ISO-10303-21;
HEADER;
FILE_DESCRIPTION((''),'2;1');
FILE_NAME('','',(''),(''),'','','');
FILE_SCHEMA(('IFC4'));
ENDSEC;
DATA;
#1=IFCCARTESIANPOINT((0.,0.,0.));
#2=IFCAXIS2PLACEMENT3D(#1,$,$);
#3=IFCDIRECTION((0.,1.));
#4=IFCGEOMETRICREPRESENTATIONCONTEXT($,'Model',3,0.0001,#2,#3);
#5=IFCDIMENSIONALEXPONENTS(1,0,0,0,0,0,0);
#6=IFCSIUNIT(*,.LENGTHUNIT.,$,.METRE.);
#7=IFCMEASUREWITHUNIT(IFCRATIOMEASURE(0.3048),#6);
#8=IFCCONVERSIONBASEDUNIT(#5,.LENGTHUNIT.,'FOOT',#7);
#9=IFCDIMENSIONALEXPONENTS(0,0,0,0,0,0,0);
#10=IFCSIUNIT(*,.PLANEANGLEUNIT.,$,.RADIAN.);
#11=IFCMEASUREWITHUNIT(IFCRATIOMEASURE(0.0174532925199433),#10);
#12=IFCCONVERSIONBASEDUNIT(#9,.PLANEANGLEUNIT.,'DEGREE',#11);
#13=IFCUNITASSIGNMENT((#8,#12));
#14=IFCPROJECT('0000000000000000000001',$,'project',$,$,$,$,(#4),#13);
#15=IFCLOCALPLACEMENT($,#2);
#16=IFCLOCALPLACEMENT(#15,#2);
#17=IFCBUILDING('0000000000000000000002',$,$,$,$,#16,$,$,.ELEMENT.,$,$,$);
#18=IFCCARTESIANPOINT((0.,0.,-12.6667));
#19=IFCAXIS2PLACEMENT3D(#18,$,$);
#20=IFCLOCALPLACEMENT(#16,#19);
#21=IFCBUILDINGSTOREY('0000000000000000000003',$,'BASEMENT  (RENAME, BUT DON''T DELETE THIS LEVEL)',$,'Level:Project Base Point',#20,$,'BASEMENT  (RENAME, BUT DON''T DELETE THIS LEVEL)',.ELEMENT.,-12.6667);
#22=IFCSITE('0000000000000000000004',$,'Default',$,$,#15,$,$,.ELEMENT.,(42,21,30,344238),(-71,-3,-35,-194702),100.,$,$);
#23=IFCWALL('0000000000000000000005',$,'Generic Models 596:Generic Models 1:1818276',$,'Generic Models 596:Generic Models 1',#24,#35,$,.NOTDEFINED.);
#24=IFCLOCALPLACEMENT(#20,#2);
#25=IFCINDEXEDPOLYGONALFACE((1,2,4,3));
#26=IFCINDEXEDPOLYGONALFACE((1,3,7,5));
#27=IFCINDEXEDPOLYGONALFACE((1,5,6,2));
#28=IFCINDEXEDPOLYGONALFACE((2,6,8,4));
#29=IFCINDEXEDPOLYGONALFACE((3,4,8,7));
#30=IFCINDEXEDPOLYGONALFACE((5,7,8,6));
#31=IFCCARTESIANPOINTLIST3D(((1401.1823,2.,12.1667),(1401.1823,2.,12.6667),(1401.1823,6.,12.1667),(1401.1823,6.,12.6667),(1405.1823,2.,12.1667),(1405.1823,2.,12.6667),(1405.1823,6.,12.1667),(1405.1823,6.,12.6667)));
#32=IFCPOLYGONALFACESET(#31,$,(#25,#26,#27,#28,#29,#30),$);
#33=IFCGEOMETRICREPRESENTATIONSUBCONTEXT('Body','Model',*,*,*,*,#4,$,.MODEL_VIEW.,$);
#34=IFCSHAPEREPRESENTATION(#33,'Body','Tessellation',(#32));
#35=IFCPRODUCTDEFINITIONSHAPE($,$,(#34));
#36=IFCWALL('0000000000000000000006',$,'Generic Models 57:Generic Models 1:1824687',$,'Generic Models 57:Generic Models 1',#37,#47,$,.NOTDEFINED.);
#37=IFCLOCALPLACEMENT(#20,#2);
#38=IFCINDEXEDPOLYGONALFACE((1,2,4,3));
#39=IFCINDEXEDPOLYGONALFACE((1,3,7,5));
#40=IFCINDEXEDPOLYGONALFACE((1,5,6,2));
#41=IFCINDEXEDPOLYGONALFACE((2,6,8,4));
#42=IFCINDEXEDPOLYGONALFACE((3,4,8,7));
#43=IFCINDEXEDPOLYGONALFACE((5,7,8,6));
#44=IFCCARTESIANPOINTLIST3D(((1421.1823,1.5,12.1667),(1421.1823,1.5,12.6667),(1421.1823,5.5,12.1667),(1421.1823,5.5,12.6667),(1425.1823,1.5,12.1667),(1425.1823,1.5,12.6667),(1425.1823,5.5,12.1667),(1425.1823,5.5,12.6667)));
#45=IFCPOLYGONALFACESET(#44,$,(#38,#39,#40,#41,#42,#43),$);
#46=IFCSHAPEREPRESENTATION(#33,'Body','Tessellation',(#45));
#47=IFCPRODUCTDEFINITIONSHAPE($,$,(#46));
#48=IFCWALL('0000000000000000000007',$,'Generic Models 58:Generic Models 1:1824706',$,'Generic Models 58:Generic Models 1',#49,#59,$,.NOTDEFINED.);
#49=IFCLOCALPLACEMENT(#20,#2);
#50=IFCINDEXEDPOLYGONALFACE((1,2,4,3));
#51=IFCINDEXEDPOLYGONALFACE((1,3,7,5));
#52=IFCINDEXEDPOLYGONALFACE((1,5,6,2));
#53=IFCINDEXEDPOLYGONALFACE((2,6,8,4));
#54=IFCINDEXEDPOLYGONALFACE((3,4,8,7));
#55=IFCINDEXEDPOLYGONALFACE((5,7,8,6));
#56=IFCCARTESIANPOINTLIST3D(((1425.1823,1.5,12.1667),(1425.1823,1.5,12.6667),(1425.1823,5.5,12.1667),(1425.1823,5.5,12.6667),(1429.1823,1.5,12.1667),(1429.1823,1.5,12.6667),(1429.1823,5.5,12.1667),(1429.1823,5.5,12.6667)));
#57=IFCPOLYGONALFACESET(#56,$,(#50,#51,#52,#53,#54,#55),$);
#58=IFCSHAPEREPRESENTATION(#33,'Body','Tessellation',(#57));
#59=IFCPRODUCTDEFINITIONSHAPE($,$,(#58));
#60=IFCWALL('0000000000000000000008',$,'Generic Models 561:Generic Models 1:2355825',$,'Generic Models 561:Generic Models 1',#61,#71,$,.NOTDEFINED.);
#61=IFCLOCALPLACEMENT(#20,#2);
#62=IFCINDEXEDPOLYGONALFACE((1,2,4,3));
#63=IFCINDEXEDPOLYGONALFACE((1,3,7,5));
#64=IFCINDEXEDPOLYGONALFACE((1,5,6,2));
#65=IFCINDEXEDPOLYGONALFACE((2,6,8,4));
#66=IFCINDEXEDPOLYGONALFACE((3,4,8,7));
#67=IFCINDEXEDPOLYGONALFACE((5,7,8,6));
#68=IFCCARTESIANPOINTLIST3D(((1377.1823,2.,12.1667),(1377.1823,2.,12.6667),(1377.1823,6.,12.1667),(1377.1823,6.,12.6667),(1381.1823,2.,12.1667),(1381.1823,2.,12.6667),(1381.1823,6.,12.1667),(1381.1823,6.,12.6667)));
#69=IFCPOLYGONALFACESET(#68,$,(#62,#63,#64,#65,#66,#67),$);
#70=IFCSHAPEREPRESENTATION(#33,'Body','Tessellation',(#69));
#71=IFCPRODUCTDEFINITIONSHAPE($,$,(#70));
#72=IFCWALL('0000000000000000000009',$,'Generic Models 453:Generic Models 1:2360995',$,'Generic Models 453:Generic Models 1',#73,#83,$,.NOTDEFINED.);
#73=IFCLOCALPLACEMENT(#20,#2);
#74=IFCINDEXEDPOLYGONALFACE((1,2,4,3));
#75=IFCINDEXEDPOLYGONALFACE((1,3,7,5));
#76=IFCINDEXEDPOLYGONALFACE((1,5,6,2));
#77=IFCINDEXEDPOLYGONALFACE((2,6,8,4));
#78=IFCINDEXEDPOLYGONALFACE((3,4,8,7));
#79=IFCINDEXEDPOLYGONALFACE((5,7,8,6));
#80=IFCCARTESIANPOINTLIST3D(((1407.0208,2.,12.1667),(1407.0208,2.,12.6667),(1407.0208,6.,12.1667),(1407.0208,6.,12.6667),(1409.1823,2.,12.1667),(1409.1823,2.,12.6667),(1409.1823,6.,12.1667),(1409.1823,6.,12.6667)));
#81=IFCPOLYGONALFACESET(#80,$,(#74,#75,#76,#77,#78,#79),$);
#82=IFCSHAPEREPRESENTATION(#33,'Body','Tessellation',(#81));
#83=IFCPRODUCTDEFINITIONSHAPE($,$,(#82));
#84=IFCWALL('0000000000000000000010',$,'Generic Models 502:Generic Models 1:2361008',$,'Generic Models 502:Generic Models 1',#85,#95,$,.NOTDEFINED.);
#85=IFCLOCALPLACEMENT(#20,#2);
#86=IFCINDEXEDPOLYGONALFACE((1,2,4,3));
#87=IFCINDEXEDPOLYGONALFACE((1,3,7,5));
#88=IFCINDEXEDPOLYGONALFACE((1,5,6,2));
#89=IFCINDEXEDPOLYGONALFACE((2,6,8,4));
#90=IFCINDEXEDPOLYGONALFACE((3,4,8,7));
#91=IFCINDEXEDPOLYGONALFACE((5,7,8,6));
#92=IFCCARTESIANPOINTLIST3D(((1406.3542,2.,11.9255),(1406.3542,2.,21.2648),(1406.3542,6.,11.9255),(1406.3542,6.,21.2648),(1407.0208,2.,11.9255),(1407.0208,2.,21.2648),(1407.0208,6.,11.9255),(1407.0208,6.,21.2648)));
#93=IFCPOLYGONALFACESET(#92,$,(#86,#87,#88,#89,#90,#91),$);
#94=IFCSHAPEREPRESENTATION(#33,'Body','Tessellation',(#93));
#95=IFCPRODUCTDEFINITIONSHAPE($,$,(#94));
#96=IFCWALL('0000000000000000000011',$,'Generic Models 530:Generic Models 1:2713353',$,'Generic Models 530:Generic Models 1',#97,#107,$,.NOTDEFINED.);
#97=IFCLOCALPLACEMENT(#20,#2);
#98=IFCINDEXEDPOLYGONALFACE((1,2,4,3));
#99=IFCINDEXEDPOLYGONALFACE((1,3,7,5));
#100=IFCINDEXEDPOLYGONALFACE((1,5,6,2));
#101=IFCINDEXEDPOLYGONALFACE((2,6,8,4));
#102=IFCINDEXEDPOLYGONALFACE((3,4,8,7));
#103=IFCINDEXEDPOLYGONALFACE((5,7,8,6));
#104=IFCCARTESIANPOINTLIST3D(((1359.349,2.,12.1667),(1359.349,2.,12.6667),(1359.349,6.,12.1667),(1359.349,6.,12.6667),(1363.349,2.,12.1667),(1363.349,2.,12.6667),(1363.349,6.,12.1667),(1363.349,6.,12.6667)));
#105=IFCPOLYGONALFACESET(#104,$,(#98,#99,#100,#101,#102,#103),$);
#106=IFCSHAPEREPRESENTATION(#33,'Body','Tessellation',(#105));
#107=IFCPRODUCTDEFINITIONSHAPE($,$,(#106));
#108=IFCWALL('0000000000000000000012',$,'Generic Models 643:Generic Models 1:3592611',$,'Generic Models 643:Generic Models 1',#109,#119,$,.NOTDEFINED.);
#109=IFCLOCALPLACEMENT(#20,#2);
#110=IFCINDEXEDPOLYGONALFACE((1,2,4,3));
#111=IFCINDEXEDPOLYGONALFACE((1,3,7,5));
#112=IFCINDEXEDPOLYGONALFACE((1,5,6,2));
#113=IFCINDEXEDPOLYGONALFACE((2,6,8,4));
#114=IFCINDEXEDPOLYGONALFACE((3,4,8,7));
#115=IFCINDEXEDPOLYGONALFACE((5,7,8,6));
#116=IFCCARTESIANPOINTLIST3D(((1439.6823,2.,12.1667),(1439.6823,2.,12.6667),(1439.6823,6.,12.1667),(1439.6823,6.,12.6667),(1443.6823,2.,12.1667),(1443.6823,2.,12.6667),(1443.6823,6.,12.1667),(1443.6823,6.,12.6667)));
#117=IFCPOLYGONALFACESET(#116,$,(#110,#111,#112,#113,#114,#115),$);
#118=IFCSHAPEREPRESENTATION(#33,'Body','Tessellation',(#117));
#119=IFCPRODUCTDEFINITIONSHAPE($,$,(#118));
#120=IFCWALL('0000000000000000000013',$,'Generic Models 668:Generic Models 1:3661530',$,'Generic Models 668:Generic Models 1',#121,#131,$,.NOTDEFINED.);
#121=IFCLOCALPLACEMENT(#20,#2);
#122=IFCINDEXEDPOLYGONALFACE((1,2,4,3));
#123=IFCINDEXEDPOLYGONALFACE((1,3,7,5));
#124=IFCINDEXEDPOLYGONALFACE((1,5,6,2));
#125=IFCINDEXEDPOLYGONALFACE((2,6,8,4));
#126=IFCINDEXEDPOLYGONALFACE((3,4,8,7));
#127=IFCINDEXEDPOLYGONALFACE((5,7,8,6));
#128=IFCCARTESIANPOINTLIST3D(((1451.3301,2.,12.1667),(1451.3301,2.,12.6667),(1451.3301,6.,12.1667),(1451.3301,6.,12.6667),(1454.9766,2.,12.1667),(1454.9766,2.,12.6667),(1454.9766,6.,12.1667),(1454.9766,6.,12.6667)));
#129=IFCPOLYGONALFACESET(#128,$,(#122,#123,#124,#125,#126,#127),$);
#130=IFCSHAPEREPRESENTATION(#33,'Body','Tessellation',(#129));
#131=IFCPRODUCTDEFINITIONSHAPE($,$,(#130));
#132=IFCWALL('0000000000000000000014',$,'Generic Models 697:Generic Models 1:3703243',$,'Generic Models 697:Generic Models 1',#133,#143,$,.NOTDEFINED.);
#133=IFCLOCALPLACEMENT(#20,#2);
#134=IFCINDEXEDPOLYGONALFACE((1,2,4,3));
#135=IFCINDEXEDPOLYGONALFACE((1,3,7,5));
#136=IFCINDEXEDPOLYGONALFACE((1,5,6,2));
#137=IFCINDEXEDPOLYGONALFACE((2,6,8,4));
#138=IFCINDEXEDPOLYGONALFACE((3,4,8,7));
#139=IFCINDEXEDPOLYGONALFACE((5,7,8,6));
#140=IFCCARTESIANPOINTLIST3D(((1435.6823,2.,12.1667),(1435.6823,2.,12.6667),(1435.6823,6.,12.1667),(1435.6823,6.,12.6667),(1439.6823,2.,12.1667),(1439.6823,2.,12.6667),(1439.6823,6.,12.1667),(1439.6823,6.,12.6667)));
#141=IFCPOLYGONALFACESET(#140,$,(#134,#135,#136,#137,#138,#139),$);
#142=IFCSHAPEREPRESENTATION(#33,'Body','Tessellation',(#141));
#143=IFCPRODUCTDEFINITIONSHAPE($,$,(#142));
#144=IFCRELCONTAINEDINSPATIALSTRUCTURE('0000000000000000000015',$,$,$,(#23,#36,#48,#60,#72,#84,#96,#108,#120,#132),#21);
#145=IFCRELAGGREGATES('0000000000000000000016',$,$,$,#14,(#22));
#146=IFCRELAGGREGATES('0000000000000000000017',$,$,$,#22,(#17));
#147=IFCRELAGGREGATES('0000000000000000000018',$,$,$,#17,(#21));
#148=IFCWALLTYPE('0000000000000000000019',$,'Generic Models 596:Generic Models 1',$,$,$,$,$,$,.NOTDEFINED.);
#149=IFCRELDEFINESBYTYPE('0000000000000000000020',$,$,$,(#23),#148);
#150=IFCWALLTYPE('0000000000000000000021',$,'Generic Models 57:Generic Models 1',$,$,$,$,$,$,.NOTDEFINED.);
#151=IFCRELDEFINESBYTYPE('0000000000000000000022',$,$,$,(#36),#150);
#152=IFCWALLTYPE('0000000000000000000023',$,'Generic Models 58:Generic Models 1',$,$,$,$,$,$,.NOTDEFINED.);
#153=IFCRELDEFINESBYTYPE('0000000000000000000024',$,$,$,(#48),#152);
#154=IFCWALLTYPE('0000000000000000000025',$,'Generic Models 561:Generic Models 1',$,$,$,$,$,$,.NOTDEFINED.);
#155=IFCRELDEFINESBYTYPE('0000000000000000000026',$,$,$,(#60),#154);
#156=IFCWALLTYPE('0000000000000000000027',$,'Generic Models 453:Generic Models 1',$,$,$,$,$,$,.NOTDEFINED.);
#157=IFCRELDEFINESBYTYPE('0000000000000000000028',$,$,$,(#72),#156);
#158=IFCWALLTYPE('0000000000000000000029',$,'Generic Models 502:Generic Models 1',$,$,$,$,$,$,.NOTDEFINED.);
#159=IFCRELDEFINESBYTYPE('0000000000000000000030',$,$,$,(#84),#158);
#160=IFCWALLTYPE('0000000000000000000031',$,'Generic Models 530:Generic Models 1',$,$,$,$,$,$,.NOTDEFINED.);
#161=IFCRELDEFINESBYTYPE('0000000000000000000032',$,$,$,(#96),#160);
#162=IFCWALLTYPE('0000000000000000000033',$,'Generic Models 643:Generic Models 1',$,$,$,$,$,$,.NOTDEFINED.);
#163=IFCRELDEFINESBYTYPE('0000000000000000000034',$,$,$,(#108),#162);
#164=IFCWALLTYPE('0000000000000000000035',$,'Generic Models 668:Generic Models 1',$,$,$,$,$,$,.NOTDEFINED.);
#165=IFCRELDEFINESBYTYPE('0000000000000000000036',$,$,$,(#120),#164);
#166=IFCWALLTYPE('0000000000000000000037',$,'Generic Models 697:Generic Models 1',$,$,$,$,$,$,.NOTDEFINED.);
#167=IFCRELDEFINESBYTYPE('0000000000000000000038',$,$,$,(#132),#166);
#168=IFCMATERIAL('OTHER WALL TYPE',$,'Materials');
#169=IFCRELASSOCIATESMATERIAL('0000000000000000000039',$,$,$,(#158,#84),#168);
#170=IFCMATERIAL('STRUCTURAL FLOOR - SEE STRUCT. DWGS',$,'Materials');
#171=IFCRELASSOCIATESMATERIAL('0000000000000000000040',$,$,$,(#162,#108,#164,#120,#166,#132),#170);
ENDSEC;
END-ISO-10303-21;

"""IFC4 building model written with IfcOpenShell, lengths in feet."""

from ifc_helpers import new_model, entity, si_unit, converted_unit, direction, frame, frame_2d, origin, origin_2d_with_axis, place, context, subcontext, project, spatial, rectangle, extrude, material, type_object, element, save


model = new_model("IFC4")

# Units and contexts
model_context = context("Model", 3, precision=0.0001, world=origin(), true_north=direction((0.0, 1.0)))
body_context = subcontext(model_context, "Body", "Model", "MODEL_VIEW")
ifc_project = project(units=[converted_unit("LENGTHUNIT", "FOOT", entity("IfcRatioMeasure", 0.3048), si_unit("LENGTHUNIT", "METRE"), dimensions=[1, 0, 0, 0, 0, 0, 0]), converted_unit("PLANEANGLEUNIT", "DEGREE", entity("IfcRatioMeasure", 0.0174532925199433), si_unit("PLANEANGLEUNIT", "RADIAN"), dimensions=[0, 0, 0, 0, 0, 0, 0])], contexts=[model_context])

# Site, building, storey
site_placement = place(None, origin())
site = spatial("IfcSite", under=ifc_project, at=site_placement, Name="Default", CompositionType="ELEMENT", RefLatitude=(42, 21, 30, 344238), RefLongitude=(-71, -3, -35, -194702), RefElevation=100.0)
building_placement = place(site_placement, origin())
building = spatial("IfcBuilding", under=site, at=building_placement, CompositionType="ELEMENT")
storey_placement = place(building_placement, frame((0.0, 0.0, -12.6667)))
storey = spatial("IfcBuildingStorey", under=building, at=storey_placement, Name="BASEMENT  (RENAME, BUT DON'T DELETE THIS LEVEL)", ObjectType="Level:Project Base Point", LongName="BASEMENT  (RENAME, BUT DON'T DELETE THIS LEVEL)", CompositionType="ELEMENT", Elevation=-12.6667)

# Walls
ifc_material_1 = material(Name="STRUCTURAL FLOOR - SEE STRUCT. DWGS", Category="Materials")
ifc_material_2 = material(Name="OTHER WALL TYPE", Category="Materials")
wall_type_1 = type_object("IfcWallType", Name="Generic Models 596:Generic Models 1", PredefinedType="NOTDEFINED")
wall_1_placement = place(storey_placement, frame((1401.1823, 2.0, 12.1667), z_axis=(0.0, 0.0, 1.0), x_axis=(0.0, 1.0, 0.0)))
element("IfcWall", 1, at=wall_1_placement, inside=storey, type_object=wall_type_1, Name="Generic Models 596:Generic Models 1:1818276", ObjectType="Generic Models 596:Generic Models 1", PredefinedType="NOTDEFINED", context=body_context, shape_type="SweptSolid", body=[
    extrude(rectangle(XDim=4.0, YDim=4.0, at=origin_2d_with_axis()), frame((2.0, -2.0, 0.0)), (0.0, 0.0, 1.0), 0.5),
])
wall_type_2 = type_object("IfcWallType", Name="Generic Models 57:Generic Models 1", PredefinedType="NOTDEFINED")
wall_2_placement = place(storey_placement, frame((1421.1823, 1.5, 12.1667), z_axis=(0.0, 0.0, 1.0), x_axis=(0.0, 1.0, 0.0)))
element("IfcWall", 2, at=wall_2_placement, inside=storey, type_object=wall_type_2, Name="Generic Models 57:Generic Models 1:1824687", ObjectType="Generic Models 57:Generic Models 1", PredefinedType="NOTDEFINED", context=body_context, shape_type="SweptSolid", body=[
    extrude(rectangle(XDim=4.0, YDim=4.0, at=frame_2d((0.0, 0.0), x_axis=(1.0, 0.0))), frame((2.0, -2.0, 0.0)), (0.0, 0.0, 1.0), 0.5),
])
wall_type_3 = type_object("IfcWallType", Name="Generic Models 58:Generic Models 1", PredefinedType="NOTDEFINED")
wall_3_placement = place(storey_placement, frame((1425.1823, 1.5, 12.1667), z_axis=(0.0, 0.0, 1.0), x_axis=(0.0, 1.0, 0.0)))
element("IfcWall", 3, at=wall_3_placement, inside=storey, type_object=wall_type_3, Name="Generic Models 58:Generic Models 1:1824706", ObjectType="Generic Models 58:Generic Models 1", PredefinedType="NOTDEFINED", context=body_context, shape_type="SweptSolid", body=[
    extrude(rectangle(XDim=4.0, YDim=4.0, at=origin_2d_with_axis()), frame((2.0, -2.0, 0.0)), (0.0, 0.0, 1.0), 0.5),
])
wall_type_4 = type_object("IfcWallType", Name="Generic Models 561:Generic Models 1", PredefinedType="NOTDEFINED")
wall_4_placement = place(storey_placement, frame((1377.1823, 2.0, 12.1667), z_axis=(0.0, 0.0, 1.0), x_axis=(0.0, 1.0, 0.0)))
element("IfcWall", 4, at=wall_4_placement, inside=storey, type_object=wall_type_4, Name="Generic Models 561:Generic Models 1:2355825", ObjectType="Generic Models 561:Generic Models 1", PredefinedType="NOTDEFINED", context=body_context, shape_type="SweptSolid", body=[
    extrude(rectangle(XDim=4.0, YDim=4.0, at=frame_2d((0.0, 0.0), x_axis=(1.0, 0.0))), frame((2.0, -2.0, 0.0)), (0.0, 0.0, 1.0), 0.5),
])
wall_type_5 = type_object("IfcWallType", Name="Generic Models 453:Generic Models 1", PredefinedType="NOTDEFINED")
wall_5_placement = place(storey_placement, frame((1407.0208, 2.0, 12.1667), z_axis=(0.0, 0.0, 1.0), x_axis=(0.0, 1.0, 0.0)))
element("IfcWall", 5, at=wall_5_placement, inside=storey, type_object=wall_type_5, Name="Generic Models 453:Generic Models 1:2360995", ObjectType="Generic Models 453:Generic Models 1", PredefinedType="NOTDEFINED", context=body_context, shape_type="SweptSolid", body=[
    extrude(rectangle(XDim=4.0, YDim=2.1615, at=frame_2d((0.0, 0.0), x_axis=(1.0, 0.0))), frame((2.0, -1.0807, 0.0)), (0.0, 0.0, 1.0), 0.5),
])
wall_type_6 = type_object("IfcWallType", Name="Generic Models 502:Generic Models 1", PredefinedType="NOTDEFINED", material=ifc_material_2)
wall_6_placement = place(storey_placement, frame((1406.3542, 2.0, 11.9255), z_axis=(0.0, 0.0, 1.0), x_axis=(0.0, 1.0, 0.0)))
element("IfcWall", 6, at=wall_6_placement, inside=storey, type_object=wall_type_6, material=ifc_material_2, Name="Generic Models 502:Generic Models 1:2361008", ObjectType="Generic Models 502:Generic Models 1", PredefinedType="NOTDEFINED", context=body_context, shape_type="SweptSolid", body=[
    extrude(rectangle(XDim=4.0, YDim=0.6667, at=frame_2d((0.0, 0.0), x_axis=(1.0, 0.0))), frame((2.0, -0.3333, 0.0)), (0.0, 0.0, 1.0), 9.3393),
])
wall_type_7 = type_object("IfcWallType", Name="Generic Models 530:Generic Models 1", PredefinedType="NOTDEFINED")
wall_7_placement = place(storey_placement, frame((1359.349, 2.0, 12.1667), z_axis=(0.0, 0.0, 1.0), x_axis=(0.0, 1.0, 0.0)))
element("IfcWall", 7, at=wall_7_placement, inside=storey, type_object=wall_type_7, Name="Generic Models 530:Generic Models 1:2713353", ObjectType="Generic Models 530:Generic Models 1", PredefinedType="NOTDEFINED", context=body_context, shape_type="SweptSolid", body=[
    extrude(rectangle(XDim=4.0, YDim=4.0, at=origin_2d_with_axis()), frame((2.0, -2.0, 0.0)), (0.0, 0.0, 1.0), 0.5),
])
wall_type_8 = type_object("IfcWallType", Name="Generic Models 643:Generic Models 1", PredefinedType="NOTDEFINED", material=ifc_material_1)
wall_8_placement = place(storey_placement, frame((1439.6823, 2.0, 12.1667), z_axis=(0.0, 0.0, 1.0), x_axis=(0.0, 1.0, 0.0)))
element("IfcWall", 8, at=wall_8_placement, inside=storey, type_object=wall_type_8, material=ifc_material_1, Name="Generic Models 643:Generic Models 1:3592611", ObjectType="Generic Models 643:Generic Models 1", PredefinedType="NOTDEFINED", context=body_context, shape_type="SweptSolid", body=[
    extrude(rectangle(XDim=4.0, YDim=4.0, at=origin_2d_with_axis()), frame((2.0, -2.0, 0.0)), (0.0, 0.0, 1.0), 0.5),
])
wall_type_9 = type_object("IfcWallType", Name="Generic Models 668:Generic Models 1", PredefinedType="NOTDEFINED", material=ifc_material_1)
wall_9_placement = place(storey_placement, frame((1451.3301, 2.0, 12.1667), z_axis=(0.0, 0.0, 1.0), x_axis=(0.0, 1.0, 0.0)))
element("IfcWall", 9, at=wall_9_placement, inside=storey, type_object=wall_type_9, material=ifc_material_1, Name="Generic Models 668:Generic Models 1:3661530", ObjectType="Generic Models 668:Generic Models 1", PredefinedType="NOTDEFINED", context=body_context, shape_type="SweptSolid", body=[
    extrude(rectangle(XDim=4.0, YDim=3.6465, at=frame_2d((0.0, 0.0), x_axis=(1.0, 0.0))), frame((2.0, -1.8232, 0.0)), (0.0, 0.0, 1.0), 0.5),
])
wall_type_10 = type_object("IfcWallType", Name="Generic Models 697:Generic Models 1", PredefinedType="NOTDEFINED", material=ifc_material_1)
wall_10_placement = place(storey_placement, frame((1435.6823, 2.0, 12.1667), z_axis=(0.0, 0.0, 1.0), x_axis=(0.0, 1.0, 0.0)))
element("IfcWall", 10, at=wall_10_placement, inside=storey, type_object=wall_type_10, material=ifc_material_1, Name="Generic Models 697:Generic Models 1:3703243", ObjectType="Generic Models 697:Generic Models 1", PredefinedType="NOTDEFINED", context=body_context, shape_type="SweptSolid", body=[
    extrude(rectangle(XDim=4.0, YDim=4.0, at=frame_2d((0.0, 0.0), x_axis=(1.0, 0.0))), frame((2.0, -2.0, 0.0)), (0.0, 0.0, 1.0), 0.5),
])

save(model, "model.ifc")
